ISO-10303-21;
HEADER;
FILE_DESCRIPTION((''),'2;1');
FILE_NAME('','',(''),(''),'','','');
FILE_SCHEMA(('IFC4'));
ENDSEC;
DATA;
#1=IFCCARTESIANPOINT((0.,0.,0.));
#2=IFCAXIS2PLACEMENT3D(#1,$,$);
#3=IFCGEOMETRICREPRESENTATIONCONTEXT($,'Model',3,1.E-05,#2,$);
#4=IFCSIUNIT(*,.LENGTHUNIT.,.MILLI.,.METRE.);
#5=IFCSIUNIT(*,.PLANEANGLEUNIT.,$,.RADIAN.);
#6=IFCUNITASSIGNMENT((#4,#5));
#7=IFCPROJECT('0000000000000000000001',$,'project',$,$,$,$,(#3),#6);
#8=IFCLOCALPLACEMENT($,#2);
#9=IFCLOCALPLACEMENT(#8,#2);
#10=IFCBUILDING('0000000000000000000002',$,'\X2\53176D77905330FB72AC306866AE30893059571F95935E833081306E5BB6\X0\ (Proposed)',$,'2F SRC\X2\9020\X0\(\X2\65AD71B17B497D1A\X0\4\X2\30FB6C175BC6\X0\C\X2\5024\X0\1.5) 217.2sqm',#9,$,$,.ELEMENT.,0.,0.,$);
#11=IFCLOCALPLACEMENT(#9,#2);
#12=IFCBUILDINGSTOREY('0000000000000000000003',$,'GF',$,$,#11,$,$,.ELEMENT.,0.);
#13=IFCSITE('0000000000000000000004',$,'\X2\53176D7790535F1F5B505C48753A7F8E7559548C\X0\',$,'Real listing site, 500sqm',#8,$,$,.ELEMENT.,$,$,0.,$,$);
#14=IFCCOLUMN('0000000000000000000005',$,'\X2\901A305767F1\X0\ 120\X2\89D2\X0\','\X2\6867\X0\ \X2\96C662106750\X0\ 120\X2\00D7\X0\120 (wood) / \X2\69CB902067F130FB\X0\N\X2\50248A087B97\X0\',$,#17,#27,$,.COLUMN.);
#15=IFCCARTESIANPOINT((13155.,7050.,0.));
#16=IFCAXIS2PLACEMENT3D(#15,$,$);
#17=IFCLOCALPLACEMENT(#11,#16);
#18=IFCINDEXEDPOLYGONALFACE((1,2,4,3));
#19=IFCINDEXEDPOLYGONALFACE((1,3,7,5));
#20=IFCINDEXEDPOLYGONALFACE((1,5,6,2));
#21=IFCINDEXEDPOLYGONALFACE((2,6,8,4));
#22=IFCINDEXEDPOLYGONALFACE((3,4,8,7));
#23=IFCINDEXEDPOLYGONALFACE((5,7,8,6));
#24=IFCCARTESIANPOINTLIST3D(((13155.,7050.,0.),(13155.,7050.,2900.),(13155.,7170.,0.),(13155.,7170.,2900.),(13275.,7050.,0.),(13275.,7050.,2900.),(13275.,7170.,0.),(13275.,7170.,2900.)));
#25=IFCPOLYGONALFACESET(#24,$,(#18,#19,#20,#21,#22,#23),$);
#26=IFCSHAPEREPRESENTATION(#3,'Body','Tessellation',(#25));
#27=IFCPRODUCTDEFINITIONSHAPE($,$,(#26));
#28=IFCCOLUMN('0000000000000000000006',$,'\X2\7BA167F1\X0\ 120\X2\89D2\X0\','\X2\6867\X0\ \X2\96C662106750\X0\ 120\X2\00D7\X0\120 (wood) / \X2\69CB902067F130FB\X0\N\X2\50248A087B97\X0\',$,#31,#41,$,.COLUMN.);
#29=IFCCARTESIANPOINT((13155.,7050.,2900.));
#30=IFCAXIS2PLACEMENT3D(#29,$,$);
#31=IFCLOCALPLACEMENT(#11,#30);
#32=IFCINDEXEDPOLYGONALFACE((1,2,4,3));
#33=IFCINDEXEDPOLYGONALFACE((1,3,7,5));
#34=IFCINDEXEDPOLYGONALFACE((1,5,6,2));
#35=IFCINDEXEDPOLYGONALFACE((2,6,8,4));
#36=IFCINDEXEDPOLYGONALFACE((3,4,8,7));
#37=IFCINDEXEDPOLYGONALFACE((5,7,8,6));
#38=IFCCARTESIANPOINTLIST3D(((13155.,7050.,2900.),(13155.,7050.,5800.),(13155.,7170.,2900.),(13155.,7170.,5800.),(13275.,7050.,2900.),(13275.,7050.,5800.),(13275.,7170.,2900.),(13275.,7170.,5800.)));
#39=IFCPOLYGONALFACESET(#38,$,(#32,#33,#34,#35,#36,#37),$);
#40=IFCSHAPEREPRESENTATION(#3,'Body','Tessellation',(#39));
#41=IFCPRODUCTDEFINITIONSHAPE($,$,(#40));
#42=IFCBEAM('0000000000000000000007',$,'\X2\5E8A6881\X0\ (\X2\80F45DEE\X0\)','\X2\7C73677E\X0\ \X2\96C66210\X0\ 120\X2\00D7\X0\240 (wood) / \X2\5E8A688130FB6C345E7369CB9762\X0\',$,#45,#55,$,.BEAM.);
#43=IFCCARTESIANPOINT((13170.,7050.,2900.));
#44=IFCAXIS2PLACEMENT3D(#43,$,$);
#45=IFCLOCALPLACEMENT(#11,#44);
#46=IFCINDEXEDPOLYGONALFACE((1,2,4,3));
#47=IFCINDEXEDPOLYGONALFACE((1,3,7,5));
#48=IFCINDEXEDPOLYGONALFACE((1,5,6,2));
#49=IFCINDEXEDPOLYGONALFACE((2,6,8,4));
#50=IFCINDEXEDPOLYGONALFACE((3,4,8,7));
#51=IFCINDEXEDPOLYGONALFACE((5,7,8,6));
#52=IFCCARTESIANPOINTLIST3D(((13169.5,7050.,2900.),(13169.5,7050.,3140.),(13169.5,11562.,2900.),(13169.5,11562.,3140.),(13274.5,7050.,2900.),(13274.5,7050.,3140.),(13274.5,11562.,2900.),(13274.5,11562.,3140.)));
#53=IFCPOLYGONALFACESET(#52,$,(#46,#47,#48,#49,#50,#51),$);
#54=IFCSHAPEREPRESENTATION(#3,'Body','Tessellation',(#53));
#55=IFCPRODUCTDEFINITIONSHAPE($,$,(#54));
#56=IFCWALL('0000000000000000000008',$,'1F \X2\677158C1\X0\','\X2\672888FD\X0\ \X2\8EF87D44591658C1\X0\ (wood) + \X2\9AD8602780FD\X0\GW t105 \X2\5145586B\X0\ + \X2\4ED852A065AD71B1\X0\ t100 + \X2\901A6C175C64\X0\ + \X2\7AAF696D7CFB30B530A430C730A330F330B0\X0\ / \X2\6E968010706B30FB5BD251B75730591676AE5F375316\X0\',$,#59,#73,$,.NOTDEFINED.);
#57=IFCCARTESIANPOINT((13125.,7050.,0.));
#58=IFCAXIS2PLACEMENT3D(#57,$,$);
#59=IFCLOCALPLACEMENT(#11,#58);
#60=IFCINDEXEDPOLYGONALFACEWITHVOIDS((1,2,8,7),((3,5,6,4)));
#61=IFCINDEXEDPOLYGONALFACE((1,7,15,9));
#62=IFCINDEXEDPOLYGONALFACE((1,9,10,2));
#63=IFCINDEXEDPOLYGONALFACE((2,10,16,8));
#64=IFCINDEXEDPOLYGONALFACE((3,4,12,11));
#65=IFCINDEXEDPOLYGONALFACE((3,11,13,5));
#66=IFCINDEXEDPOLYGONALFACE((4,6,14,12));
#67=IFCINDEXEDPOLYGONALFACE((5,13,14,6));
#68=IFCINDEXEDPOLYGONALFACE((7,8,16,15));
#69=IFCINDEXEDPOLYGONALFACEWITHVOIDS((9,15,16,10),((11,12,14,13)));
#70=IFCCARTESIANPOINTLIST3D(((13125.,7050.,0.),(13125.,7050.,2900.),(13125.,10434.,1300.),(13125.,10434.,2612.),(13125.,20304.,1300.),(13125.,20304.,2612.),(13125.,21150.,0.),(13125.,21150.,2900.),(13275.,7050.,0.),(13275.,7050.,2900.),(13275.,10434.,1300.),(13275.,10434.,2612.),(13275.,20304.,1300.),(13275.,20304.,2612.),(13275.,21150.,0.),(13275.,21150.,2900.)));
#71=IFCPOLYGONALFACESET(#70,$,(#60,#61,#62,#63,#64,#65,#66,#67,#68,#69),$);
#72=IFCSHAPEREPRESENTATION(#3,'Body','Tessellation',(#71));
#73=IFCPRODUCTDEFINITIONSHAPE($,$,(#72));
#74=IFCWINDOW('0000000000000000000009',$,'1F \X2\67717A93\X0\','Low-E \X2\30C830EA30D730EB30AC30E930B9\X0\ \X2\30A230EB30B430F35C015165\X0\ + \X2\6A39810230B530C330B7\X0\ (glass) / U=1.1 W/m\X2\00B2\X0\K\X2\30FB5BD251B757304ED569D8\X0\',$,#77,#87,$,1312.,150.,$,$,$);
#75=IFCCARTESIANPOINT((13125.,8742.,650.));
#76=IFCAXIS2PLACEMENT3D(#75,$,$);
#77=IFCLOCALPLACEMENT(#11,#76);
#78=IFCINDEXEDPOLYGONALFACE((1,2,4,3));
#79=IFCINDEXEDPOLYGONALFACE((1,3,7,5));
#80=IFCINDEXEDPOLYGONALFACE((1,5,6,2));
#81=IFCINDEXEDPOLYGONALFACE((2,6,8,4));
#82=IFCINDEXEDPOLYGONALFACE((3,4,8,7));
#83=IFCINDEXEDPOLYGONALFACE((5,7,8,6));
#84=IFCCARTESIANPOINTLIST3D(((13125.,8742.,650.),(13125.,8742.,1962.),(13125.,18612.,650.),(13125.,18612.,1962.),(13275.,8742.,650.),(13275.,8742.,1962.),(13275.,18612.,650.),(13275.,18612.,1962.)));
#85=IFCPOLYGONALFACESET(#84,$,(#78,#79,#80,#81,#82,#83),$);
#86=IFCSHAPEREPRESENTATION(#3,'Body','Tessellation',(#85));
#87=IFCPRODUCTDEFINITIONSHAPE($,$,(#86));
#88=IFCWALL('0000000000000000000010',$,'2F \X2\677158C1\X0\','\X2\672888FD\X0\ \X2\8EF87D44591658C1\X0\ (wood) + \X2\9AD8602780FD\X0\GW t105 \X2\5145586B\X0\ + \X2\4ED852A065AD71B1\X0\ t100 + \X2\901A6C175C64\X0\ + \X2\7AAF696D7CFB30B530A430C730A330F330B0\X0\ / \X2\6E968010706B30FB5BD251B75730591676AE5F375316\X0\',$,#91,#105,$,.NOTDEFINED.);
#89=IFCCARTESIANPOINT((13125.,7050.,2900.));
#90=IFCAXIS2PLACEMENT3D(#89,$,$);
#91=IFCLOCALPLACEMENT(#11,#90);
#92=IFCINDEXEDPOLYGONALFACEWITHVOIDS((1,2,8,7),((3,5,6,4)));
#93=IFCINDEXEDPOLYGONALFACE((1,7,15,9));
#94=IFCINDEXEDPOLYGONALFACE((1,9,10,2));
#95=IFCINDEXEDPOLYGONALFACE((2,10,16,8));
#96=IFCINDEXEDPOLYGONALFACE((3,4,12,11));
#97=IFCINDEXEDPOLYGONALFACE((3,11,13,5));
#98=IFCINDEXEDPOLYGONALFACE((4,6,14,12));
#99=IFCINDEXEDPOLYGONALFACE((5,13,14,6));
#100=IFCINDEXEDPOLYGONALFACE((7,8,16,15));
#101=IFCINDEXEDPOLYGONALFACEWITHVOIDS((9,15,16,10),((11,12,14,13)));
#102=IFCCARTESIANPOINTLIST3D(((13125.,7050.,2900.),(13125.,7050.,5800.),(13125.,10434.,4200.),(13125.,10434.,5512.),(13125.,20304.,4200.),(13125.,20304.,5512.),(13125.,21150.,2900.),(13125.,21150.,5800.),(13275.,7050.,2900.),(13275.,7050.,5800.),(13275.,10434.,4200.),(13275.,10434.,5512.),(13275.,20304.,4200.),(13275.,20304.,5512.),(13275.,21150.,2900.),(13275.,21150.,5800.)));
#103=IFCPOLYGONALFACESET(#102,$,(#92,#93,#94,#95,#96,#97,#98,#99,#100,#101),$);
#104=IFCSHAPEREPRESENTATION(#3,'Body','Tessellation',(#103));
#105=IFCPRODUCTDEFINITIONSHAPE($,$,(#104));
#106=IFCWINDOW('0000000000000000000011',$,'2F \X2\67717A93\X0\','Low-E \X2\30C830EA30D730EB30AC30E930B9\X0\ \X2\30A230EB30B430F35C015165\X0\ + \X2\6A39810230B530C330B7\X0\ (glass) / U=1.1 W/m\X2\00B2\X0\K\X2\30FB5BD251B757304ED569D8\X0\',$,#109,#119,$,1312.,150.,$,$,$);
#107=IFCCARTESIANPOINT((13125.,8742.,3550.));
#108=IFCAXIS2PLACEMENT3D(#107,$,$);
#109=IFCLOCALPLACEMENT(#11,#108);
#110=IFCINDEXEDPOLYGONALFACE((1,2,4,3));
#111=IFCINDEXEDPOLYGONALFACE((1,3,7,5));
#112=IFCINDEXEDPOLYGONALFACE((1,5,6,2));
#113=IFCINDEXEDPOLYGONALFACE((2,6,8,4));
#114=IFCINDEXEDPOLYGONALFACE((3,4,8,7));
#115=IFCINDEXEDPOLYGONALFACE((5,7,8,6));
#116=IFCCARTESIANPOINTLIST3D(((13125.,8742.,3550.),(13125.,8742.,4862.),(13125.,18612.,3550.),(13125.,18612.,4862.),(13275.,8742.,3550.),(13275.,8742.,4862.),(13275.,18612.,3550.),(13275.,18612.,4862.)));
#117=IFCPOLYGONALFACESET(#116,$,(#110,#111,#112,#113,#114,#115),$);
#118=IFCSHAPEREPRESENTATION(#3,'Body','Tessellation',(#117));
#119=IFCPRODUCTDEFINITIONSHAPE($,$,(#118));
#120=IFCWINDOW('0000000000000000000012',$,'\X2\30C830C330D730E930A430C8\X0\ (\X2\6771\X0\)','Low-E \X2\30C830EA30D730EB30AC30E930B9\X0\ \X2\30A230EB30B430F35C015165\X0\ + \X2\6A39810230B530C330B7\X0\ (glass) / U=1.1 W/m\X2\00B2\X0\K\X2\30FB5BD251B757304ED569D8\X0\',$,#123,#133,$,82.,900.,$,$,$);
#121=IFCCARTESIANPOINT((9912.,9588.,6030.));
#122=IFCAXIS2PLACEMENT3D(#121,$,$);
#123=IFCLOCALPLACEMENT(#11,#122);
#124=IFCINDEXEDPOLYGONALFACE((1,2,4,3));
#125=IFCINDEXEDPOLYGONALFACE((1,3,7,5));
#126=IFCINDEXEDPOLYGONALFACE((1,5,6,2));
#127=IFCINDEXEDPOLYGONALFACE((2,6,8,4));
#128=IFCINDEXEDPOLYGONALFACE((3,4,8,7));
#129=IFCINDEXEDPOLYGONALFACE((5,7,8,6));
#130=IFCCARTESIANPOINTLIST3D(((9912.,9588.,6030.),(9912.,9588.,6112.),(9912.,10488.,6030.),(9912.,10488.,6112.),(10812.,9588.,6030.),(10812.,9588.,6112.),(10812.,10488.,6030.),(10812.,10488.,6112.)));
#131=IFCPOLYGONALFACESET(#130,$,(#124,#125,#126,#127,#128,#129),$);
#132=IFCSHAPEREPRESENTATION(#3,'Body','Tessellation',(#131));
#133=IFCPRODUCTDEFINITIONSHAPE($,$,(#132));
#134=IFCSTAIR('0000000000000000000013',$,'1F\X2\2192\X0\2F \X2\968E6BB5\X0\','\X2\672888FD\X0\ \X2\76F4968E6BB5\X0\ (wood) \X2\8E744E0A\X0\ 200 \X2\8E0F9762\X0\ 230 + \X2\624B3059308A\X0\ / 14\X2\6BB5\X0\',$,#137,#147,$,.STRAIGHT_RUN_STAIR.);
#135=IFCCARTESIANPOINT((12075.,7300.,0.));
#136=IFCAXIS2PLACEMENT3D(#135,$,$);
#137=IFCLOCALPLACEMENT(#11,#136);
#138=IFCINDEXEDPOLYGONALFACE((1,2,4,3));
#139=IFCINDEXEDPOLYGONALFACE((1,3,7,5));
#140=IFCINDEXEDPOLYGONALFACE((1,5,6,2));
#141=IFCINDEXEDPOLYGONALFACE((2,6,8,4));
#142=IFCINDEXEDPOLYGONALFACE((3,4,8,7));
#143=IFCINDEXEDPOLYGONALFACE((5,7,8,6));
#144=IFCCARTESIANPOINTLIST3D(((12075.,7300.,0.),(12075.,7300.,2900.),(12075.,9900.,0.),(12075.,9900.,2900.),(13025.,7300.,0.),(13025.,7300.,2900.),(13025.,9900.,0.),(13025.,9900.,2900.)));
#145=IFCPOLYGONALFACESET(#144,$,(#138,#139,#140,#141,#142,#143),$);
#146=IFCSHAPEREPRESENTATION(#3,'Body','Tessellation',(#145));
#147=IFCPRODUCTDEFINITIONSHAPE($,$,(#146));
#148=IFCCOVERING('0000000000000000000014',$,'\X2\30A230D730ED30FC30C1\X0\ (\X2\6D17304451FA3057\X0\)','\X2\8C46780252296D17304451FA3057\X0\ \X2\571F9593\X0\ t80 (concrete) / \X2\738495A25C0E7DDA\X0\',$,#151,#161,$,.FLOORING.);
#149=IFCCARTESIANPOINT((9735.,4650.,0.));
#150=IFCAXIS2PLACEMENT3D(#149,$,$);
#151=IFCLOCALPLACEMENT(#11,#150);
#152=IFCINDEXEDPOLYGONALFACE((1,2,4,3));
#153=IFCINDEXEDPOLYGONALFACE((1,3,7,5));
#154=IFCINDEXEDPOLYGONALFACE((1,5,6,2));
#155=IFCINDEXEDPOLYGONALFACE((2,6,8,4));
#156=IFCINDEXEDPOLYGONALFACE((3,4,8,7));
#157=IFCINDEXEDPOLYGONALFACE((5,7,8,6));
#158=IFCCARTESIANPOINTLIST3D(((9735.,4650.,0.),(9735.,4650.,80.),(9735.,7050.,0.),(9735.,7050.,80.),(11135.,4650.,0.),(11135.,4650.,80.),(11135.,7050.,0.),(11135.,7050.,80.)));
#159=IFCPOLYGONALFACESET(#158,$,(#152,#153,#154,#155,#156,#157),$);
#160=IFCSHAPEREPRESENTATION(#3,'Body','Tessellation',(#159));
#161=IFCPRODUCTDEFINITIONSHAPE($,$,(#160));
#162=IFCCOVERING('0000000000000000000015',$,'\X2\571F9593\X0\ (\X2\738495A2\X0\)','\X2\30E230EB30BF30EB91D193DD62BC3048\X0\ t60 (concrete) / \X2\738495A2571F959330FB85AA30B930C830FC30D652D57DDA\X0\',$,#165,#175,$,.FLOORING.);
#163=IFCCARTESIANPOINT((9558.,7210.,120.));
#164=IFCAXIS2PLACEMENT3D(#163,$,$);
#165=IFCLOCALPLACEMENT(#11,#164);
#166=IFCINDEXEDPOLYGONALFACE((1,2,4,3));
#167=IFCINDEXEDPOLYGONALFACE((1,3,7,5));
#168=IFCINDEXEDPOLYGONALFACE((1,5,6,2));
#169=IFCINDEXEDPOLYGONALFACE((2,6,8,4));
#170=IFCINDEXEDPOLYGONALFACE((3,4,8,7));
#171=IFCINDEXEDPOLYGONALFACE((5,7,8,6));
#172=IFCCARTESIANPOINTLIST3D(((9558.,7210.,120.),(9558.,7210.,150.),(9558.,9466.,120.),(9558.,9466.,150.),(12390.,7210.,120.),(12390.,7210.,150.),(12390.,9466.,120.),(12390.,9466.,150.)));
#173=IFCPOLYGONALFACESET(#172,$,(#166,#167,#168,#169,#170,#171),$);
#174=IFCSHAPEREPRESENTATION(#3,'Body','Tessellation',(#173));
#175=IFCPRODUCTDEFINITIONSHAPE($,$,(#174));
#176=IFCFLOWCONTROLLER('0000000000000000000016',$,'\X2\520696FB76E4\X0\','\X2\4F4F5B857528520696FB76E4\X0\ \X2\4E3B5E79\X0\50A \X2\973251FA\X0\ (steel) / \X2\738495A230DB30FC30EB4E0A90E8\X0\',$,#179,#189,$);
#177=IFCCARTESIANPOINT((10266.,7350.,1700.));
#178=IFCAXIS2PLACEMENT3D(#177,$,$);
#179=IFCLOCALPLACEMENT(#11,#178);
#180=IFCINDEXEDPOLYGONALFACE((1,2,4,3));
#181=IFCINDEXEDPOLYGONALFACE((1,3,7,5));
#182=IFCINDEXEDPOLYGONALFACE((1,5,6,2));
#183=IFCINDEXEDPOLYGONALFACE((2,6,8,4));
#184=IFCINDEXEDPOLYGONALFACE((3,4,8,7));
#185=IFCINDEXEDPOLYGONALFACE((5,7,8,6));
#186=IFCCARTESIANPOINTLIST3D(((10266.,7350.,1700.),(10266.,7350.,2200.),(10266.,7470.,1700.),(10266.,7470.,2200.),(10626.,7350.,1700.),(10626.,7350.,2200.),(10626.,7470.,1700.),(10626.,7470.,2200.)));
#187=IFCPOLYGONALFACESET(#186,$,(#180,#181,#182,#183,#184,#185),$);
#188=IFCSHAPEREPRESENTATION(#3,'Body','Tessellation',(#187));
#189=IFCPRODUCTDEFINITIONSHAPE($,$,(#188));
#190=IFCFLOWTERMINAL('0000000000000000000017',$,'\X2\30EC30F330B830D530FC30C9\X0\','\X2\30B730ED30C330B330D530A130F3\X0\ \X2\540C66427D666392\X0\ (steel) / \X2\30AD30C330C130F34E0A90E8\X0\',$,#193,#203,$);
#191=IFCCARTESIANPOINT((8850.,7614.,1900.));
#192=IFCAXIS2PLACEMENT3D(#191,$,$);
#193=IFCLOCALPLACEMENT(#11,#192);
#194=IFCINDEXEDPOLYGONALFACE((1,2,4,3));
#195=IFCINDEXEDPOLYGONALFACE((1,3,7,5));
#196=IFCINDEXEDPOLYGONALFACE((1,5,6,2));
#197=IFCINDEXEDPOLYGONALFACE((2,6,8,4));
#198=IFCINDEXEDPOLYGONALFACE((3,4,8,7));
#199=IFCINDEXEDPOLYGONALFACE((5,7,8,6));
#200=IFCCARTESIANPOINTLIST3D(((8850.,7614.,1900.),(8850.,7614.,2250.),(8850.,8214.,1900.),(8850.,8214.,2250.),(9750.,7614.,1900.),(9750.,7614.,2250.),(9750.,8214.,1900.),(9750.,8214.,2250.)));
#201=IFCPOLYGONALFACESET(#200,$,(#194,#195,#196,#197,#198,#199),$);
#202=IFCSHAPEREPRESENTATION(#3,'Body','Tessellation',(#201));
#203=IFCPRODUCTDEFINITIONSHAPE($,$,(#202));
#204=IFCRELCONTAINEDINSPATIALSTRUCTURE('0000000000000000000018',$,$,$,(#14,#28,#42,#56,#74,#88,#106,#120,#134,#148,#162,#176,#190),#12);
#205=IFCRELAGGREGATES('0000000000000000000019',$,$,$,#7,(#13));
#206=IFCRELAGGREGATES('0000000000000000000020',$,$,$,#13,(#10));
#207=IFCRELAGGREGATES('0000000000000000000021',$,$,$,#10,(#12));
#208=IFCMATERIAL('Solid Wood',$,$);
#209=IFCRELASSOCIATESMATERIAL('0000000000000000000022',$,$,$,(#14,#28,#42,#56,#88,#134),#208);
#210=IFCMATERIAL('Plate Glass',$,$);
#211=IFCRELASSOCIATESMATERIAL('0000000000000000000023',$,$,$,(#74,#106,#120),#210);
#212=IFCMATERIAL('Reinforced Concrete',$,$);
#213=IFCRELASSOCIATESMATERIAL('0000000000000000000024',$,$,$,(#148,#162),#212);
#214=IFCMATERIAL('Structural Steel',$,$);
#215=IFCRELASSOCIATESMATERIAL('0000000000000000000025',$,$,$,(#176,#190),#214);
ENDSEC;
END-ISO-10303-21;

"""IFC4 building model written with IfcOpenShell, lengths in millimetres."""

from ifc_helpers import new_model, si_unit, frame, frame_2d, origin, place, context, project, spatial, rectangle, extrude, material, element, fill, save


model = new_model("IFC4")

# Units and contexts
model_context = context("Model", 3, precision=1e-05, world=origin())
ifc_project = project(units=[si_unit("LENGTHUNIT", "METRE", prefix="MILLI"), si_unit("PLANEANGLEUNIT", "RADIAN")], contexts=[model_context])

# Site, building, storey
site_placement = place(None, origin())
site = spatial("IfcSite", under=ifc_project, at=site_placement, Name="北海道弟子屈町美留和", ObjectType="Real listing site, 500sqm", CompositionType="ELEMENT", RefElevation=0.0)
building_placement = place(site_placement, origin())
building = spatial("IfcBuilding", under=site, at=building_placement, Name="北海道・犬と暮らす土間広めの家 (Proposed)", ObjectType="2F SRC造(断熱等級4・気密C値1.5) 217.2sqm", CompositionType="ELEMENT", ElevationOfRefHeight=0.0, ElevationOfTerrain=0.0)
storey_placement = place(building_placement, origin())
storey = spatial("IfcBuildingStorey", under=building, at=storey_placement, Name="GF", CompositionType="ELEMENT", Elevation=0.0)

# Columns
ifc_material_1 = material(Name="Solid Wood")
column_1_placement = place(storey_placement, frame((13155.0, 7050.0, 0.0)))
element("IfcColumn", 1, at=column_1_placement, inside=storey, material=ifc_material_1, Name="通し柱 120角", Description="桧 集成材 120×120 (wood) / 構造柱・N値計算", PredefinedType="COLUMN", context=model_context, shape_type="SweptSolid", body=[
    extrude(rectangle(XDim=120.0, YDim=120.0, at=frame_2d((60.0, 60.0))), frame((13155.0, 7050.0, 0.0)), (0.0, 0.0, 1.0), 2900.0),
])
column_2_placement = place(storey_placement, frame((13155.0, 7050.0, 2900.0)))
element("IfcColumn", 2, at=column_2_placement, inside=storey, material=ifc_material_1, Name="管柱 120角", Description="桧 集成材 120×120 (wood) / 構造柱・N値計算", PredefinedType="COLUMN", context=model_context, shape_type="SweptSolid", body=[
    extrude(rectangle(XDim=120.0, YDim=120.0, at=frame_2d((60.0, 60.0))), frame((13155.0, 7050.0, 2900.0)), (0.0, 0.0, 1.0), 2900.0),
])

# Beam
beam_1_placement = place(storey_placement, frame((13170.0, 7050.0, 2900.0)))
element("IfcBeam", 3, at=beam_1_placement, inside=storey, material=ifc_material_1, Name="床梁 (胴差)", Description="米松 集成 120×240 (wood) / 床梁・水平構面", PredefinedType="BEAM", context=model_context, shape_type="SweptSolid", body=[
    extrude(rectangle(XDim=105.0, YDim=4512.0, at=frame_2d((52.0, 2256.0))), frame((13170.0, 7050.0, 2900.0)), (0.0, 0.0, 1.0), 240.0),
])

# Wall, opening, window
wall_1_placement = place(storey_placement, frame((13125.0, 7050.0, 0.0)))
wall_1 = element("IfcWall", 4, at=wall_1_placement, inside=storey, material=ifc_material_1, Name="1F 東壁", Description="木製 軸組外壁 (wood) + 高性能GW t105 充填 + 付加断熱 t100 + 通気層 + 窯業系サイディング / 準耐火・寒冷地外皮強化", PredefinedType="NOTDEFINED", context=model_context, shape_type="SweptSolid", body=[
    extrude(rectangle(XDim=150.0, YDim=14100.0, at=frame_2d((75.0, 7050.0))), frame((13125.0, 7050.0, 0.0)), (0.0, 0.0, 1.0), 2900.0),
])
opening_1_placement = place(storey_placement, frame((13125.0, 8742.0, 650.0)))
opening_1 = element("IfcOpeningElement", 5, at=opening_1_placement, cuts=wall_1, PredefinedType="NOTDEFINED", context=model_context, shape_type="SweptSolid", body=[
    extrude(rectangle(XDim=150.0, YDim=9870.0, at=frame_2d((75.0, 4935.0))), frame((13125.0, 8742.0, 650.0)), (0.0, 0.0, 1.0), 1312.0),
])
ifc_material_2 = material(Name="Plate Glass")
window_1_placement = place(storey_placement, frame((13125.0, 8742.0, 650.0)))
window_1 = element("IfcWindow", 6, at=window_1_placement, inside=storey, material=ifc_material_2, Name="1F 東窓", Description="Low-E トリプルガラス アルゴン封入 + 樹脂サッシ (glass) / U=1.1 W/m²K・寒冷地仕様", OverallHeight=1312.0, OverallWidth=150.0, context=model_context, shape_type="SweptSolid", body=[
    extrude(rectangle(XDim=150.0, YDim=9870.0, at=frame_2d((75.0, 4935.0))), frame((13125.0, 8742.0, 650.0)), (0.0, 0.0, 1.0), 1312.0),
])
fill(opening_1, window_1)

# Wall, opening, window
wall_2_placement = place(storey_placement, frame((13125.0, 7050.0, 2900.0)))
wall_2 = element("IfcWall", 7, at=wall_2_placement, inside=storey, material=ifc_material_1, Name="2F 東壁", Description="木製 軸組外壁 (wood) + 高性能GW t105 充填 + 付加断熱 t100 + 通気層 + 窯業系サイディング / 準耐火・寒冷地外皮強化", PredefinedType="NOTDEFINED", context=model_context, shape_type="SweptSolid", body=[
    extrude(rectangle(XDim=150.0, YDim=14100.0, at=frame_2d((75.0, 7050.0))), frame((13125.0, 7050.0, 2900.0)), (0.0, 0.0, 1.0), 2900.0),
])
opening_2_placement = place(storey_placement, frame((13125.0, 8742.0, 3550.0)))
opening_2 = element("IfcOpeningElement", 8, at=opening_2_placement, cuts=wall_2, PredefinedType="NOTDEFINED", context=model_context, shape_type="SweptSolid", body=[
    extrude(rectangle(XDim=150.0, YDim=9870.0, at=frame_2d((75.0, 4935.0))), frame((13125.0, 8742.0, 3550.0)), (0.0, 0.0, 1.0), 1312.0),
])
window_2_placement = place(storey_placement, frame((13125.0, 8742.0, 3550.0)))
window_2 = element("IfcWindow", 9, at=window_2_placement, inside=storey, material=ifc_material_2, Name="2F 東窓", Description="Low-E トリプルガラス アルゴン封入 + 樹脂サッシ (glass) / U=1.1 W/m²K・寒冷地仕様", OverallHeight=1312.0, OverallWidth=150.0, context=model_context, shape_type="SweptSolid", body=[
    extrude(rectangle(XDim=150.0, YDim=9870.0, at=frame_2d((75.0, 4935.0))), frame((13125.0, 8742.0, 3550.0)), (0.0, 0.0, 1.0), 1312.0),
])
fill(opening_2, window_2)

# Window
window_3_placement = place(storey_placement, frame((9912.0, 9588.0, 6030.0)))
element("IfcWindow", 10, at=window_3_placement, inside=storey, material=ifc_material_2, Name="トップライト (東)", Description="Low-E トリプルガラス アルゴン封入 + 樹脂サッシ (glass) / U=1.1 W/m²K・寒冷地仕様", OverallHeight=82.0, OverallWidth=900.0, context=model_context, shape_type="SweptSolid", body=[
    extrude(rectangle(XDim=900.0, YDim=900.0, at=frame_2d((450.0, 450.0))), frame((9912.0, 9588.0, 6030.0)), (0.0, 0.0, 1.0), 82.0),
])

# Stair
stair_placement = place(storey_placement, frame((12075.0, 7300.0, 0.0)))
element("IfcStair", 11, at=stair_placement, inside=storey, material=ifc_material_1, Name="1F→2F 階段", Description="木製 直階段 (wood) 蹴上 200 踏面 230 + 手すり / 14段", PredefinedType="STRAIGHT_RUN_STAIR", context=model_context, shape_type="SweptSolid", body=[
    extrude(rectangle(XDim=950.0, YDim=2600.0, at=frame_2d((475.0, 1300.0))), frame((12075.0, 7300.0, 0.0)), (0.0, 0.0, 1.0), 2900.0),
])

# Coverings
ifc_material_3 = material(Name="Reinforced Concrete")
covering_1_placement = place(storey_placement, frame((9735.0, 4650.0, 0.0)))
element("IfcCovering", 12, at=covering_1_placement, inside=storey, material=ifc_material_3, Name="アプローチ (洗い出し)", Description="豆砂利洗い出し 土間 t80 (concrete) / 玄関導線", PredefinedType="FLOORING", context=model_context, shape_type="SweptSolid", body=[
    extrude(rectangle(XDim=1400.0, YDim=2400.0, at=frame_2d((700.0, 1200.0))), frame((9735.0, 4650.0, 0.0)), (0.0, 0.0, 1.0), 80.0),
])
covering_2_placement = place(storey_placement, frame((9558.0, 7210.0, 120.0)))
element("IfcCovering", 13, at=covering_2_placement, inside=storey, material=ifc_material_3, Name="土間 (玄関)", Description="モルタル金鏝押え t60 (concrete) / 玄関土間・薪ストーブ動線", PredefinedType="FLOORING", context=model_context, shape_type="SweptSolid", body=[
    extrude(rectangle(XDim=2832.0, YDim=2256.0, at=frame_2d((1416.0, 1128.0))), frame((9558.0, 7210.0, 120.0)), (0.0, 0.0, 1.0), 30.0),
])

# Flow controller
ifc_material_4 = material(Name="Structural Steel")
flow_controller_placement = place(storey_placement, frame((10266.0, 7350.0, 1700.0)))
element("IfcFlowController", 14, at=flow_controller_placement, inside=storey, material=ifc_material_4, Name="分電盤", Description="住宅用分電盤 主幹50A 露出 (steel) / 玄関ホール上部", context=model_context, shape_type="SweptSolid", body=[
    extrude(rectangle(XDim=360.0, YDim=120.0, at=frame_2d((180.0, 60.0))), frame((10266.0, 7350.0, 1700.0)), (0.0, 0.0, 1.0), 500.0),
])

# Flow terminal
flow_terminal_1_placement = place(storey_placement, frame((8850.0, 7614.0, 1900.0)))
element("IfcFlowTerminal", 15, at=flow_terminal_1_placement, inside=storey, material=ifc_material_4, Name="レンジフード", Description="シロッコファン 同時給排 (steel) / キッチン上部", context=model_context, shape_type="SweptSolid", body=[
    extrude(rectangle(XDim=900.0, YDim=600.0, at=frame_2d((450.0, 300.0))), frame((8850.0, 7614.0, 1900.0)), (0.0, 0.0, 1.0), 350.0),
])

save(model, "model.ifc")
